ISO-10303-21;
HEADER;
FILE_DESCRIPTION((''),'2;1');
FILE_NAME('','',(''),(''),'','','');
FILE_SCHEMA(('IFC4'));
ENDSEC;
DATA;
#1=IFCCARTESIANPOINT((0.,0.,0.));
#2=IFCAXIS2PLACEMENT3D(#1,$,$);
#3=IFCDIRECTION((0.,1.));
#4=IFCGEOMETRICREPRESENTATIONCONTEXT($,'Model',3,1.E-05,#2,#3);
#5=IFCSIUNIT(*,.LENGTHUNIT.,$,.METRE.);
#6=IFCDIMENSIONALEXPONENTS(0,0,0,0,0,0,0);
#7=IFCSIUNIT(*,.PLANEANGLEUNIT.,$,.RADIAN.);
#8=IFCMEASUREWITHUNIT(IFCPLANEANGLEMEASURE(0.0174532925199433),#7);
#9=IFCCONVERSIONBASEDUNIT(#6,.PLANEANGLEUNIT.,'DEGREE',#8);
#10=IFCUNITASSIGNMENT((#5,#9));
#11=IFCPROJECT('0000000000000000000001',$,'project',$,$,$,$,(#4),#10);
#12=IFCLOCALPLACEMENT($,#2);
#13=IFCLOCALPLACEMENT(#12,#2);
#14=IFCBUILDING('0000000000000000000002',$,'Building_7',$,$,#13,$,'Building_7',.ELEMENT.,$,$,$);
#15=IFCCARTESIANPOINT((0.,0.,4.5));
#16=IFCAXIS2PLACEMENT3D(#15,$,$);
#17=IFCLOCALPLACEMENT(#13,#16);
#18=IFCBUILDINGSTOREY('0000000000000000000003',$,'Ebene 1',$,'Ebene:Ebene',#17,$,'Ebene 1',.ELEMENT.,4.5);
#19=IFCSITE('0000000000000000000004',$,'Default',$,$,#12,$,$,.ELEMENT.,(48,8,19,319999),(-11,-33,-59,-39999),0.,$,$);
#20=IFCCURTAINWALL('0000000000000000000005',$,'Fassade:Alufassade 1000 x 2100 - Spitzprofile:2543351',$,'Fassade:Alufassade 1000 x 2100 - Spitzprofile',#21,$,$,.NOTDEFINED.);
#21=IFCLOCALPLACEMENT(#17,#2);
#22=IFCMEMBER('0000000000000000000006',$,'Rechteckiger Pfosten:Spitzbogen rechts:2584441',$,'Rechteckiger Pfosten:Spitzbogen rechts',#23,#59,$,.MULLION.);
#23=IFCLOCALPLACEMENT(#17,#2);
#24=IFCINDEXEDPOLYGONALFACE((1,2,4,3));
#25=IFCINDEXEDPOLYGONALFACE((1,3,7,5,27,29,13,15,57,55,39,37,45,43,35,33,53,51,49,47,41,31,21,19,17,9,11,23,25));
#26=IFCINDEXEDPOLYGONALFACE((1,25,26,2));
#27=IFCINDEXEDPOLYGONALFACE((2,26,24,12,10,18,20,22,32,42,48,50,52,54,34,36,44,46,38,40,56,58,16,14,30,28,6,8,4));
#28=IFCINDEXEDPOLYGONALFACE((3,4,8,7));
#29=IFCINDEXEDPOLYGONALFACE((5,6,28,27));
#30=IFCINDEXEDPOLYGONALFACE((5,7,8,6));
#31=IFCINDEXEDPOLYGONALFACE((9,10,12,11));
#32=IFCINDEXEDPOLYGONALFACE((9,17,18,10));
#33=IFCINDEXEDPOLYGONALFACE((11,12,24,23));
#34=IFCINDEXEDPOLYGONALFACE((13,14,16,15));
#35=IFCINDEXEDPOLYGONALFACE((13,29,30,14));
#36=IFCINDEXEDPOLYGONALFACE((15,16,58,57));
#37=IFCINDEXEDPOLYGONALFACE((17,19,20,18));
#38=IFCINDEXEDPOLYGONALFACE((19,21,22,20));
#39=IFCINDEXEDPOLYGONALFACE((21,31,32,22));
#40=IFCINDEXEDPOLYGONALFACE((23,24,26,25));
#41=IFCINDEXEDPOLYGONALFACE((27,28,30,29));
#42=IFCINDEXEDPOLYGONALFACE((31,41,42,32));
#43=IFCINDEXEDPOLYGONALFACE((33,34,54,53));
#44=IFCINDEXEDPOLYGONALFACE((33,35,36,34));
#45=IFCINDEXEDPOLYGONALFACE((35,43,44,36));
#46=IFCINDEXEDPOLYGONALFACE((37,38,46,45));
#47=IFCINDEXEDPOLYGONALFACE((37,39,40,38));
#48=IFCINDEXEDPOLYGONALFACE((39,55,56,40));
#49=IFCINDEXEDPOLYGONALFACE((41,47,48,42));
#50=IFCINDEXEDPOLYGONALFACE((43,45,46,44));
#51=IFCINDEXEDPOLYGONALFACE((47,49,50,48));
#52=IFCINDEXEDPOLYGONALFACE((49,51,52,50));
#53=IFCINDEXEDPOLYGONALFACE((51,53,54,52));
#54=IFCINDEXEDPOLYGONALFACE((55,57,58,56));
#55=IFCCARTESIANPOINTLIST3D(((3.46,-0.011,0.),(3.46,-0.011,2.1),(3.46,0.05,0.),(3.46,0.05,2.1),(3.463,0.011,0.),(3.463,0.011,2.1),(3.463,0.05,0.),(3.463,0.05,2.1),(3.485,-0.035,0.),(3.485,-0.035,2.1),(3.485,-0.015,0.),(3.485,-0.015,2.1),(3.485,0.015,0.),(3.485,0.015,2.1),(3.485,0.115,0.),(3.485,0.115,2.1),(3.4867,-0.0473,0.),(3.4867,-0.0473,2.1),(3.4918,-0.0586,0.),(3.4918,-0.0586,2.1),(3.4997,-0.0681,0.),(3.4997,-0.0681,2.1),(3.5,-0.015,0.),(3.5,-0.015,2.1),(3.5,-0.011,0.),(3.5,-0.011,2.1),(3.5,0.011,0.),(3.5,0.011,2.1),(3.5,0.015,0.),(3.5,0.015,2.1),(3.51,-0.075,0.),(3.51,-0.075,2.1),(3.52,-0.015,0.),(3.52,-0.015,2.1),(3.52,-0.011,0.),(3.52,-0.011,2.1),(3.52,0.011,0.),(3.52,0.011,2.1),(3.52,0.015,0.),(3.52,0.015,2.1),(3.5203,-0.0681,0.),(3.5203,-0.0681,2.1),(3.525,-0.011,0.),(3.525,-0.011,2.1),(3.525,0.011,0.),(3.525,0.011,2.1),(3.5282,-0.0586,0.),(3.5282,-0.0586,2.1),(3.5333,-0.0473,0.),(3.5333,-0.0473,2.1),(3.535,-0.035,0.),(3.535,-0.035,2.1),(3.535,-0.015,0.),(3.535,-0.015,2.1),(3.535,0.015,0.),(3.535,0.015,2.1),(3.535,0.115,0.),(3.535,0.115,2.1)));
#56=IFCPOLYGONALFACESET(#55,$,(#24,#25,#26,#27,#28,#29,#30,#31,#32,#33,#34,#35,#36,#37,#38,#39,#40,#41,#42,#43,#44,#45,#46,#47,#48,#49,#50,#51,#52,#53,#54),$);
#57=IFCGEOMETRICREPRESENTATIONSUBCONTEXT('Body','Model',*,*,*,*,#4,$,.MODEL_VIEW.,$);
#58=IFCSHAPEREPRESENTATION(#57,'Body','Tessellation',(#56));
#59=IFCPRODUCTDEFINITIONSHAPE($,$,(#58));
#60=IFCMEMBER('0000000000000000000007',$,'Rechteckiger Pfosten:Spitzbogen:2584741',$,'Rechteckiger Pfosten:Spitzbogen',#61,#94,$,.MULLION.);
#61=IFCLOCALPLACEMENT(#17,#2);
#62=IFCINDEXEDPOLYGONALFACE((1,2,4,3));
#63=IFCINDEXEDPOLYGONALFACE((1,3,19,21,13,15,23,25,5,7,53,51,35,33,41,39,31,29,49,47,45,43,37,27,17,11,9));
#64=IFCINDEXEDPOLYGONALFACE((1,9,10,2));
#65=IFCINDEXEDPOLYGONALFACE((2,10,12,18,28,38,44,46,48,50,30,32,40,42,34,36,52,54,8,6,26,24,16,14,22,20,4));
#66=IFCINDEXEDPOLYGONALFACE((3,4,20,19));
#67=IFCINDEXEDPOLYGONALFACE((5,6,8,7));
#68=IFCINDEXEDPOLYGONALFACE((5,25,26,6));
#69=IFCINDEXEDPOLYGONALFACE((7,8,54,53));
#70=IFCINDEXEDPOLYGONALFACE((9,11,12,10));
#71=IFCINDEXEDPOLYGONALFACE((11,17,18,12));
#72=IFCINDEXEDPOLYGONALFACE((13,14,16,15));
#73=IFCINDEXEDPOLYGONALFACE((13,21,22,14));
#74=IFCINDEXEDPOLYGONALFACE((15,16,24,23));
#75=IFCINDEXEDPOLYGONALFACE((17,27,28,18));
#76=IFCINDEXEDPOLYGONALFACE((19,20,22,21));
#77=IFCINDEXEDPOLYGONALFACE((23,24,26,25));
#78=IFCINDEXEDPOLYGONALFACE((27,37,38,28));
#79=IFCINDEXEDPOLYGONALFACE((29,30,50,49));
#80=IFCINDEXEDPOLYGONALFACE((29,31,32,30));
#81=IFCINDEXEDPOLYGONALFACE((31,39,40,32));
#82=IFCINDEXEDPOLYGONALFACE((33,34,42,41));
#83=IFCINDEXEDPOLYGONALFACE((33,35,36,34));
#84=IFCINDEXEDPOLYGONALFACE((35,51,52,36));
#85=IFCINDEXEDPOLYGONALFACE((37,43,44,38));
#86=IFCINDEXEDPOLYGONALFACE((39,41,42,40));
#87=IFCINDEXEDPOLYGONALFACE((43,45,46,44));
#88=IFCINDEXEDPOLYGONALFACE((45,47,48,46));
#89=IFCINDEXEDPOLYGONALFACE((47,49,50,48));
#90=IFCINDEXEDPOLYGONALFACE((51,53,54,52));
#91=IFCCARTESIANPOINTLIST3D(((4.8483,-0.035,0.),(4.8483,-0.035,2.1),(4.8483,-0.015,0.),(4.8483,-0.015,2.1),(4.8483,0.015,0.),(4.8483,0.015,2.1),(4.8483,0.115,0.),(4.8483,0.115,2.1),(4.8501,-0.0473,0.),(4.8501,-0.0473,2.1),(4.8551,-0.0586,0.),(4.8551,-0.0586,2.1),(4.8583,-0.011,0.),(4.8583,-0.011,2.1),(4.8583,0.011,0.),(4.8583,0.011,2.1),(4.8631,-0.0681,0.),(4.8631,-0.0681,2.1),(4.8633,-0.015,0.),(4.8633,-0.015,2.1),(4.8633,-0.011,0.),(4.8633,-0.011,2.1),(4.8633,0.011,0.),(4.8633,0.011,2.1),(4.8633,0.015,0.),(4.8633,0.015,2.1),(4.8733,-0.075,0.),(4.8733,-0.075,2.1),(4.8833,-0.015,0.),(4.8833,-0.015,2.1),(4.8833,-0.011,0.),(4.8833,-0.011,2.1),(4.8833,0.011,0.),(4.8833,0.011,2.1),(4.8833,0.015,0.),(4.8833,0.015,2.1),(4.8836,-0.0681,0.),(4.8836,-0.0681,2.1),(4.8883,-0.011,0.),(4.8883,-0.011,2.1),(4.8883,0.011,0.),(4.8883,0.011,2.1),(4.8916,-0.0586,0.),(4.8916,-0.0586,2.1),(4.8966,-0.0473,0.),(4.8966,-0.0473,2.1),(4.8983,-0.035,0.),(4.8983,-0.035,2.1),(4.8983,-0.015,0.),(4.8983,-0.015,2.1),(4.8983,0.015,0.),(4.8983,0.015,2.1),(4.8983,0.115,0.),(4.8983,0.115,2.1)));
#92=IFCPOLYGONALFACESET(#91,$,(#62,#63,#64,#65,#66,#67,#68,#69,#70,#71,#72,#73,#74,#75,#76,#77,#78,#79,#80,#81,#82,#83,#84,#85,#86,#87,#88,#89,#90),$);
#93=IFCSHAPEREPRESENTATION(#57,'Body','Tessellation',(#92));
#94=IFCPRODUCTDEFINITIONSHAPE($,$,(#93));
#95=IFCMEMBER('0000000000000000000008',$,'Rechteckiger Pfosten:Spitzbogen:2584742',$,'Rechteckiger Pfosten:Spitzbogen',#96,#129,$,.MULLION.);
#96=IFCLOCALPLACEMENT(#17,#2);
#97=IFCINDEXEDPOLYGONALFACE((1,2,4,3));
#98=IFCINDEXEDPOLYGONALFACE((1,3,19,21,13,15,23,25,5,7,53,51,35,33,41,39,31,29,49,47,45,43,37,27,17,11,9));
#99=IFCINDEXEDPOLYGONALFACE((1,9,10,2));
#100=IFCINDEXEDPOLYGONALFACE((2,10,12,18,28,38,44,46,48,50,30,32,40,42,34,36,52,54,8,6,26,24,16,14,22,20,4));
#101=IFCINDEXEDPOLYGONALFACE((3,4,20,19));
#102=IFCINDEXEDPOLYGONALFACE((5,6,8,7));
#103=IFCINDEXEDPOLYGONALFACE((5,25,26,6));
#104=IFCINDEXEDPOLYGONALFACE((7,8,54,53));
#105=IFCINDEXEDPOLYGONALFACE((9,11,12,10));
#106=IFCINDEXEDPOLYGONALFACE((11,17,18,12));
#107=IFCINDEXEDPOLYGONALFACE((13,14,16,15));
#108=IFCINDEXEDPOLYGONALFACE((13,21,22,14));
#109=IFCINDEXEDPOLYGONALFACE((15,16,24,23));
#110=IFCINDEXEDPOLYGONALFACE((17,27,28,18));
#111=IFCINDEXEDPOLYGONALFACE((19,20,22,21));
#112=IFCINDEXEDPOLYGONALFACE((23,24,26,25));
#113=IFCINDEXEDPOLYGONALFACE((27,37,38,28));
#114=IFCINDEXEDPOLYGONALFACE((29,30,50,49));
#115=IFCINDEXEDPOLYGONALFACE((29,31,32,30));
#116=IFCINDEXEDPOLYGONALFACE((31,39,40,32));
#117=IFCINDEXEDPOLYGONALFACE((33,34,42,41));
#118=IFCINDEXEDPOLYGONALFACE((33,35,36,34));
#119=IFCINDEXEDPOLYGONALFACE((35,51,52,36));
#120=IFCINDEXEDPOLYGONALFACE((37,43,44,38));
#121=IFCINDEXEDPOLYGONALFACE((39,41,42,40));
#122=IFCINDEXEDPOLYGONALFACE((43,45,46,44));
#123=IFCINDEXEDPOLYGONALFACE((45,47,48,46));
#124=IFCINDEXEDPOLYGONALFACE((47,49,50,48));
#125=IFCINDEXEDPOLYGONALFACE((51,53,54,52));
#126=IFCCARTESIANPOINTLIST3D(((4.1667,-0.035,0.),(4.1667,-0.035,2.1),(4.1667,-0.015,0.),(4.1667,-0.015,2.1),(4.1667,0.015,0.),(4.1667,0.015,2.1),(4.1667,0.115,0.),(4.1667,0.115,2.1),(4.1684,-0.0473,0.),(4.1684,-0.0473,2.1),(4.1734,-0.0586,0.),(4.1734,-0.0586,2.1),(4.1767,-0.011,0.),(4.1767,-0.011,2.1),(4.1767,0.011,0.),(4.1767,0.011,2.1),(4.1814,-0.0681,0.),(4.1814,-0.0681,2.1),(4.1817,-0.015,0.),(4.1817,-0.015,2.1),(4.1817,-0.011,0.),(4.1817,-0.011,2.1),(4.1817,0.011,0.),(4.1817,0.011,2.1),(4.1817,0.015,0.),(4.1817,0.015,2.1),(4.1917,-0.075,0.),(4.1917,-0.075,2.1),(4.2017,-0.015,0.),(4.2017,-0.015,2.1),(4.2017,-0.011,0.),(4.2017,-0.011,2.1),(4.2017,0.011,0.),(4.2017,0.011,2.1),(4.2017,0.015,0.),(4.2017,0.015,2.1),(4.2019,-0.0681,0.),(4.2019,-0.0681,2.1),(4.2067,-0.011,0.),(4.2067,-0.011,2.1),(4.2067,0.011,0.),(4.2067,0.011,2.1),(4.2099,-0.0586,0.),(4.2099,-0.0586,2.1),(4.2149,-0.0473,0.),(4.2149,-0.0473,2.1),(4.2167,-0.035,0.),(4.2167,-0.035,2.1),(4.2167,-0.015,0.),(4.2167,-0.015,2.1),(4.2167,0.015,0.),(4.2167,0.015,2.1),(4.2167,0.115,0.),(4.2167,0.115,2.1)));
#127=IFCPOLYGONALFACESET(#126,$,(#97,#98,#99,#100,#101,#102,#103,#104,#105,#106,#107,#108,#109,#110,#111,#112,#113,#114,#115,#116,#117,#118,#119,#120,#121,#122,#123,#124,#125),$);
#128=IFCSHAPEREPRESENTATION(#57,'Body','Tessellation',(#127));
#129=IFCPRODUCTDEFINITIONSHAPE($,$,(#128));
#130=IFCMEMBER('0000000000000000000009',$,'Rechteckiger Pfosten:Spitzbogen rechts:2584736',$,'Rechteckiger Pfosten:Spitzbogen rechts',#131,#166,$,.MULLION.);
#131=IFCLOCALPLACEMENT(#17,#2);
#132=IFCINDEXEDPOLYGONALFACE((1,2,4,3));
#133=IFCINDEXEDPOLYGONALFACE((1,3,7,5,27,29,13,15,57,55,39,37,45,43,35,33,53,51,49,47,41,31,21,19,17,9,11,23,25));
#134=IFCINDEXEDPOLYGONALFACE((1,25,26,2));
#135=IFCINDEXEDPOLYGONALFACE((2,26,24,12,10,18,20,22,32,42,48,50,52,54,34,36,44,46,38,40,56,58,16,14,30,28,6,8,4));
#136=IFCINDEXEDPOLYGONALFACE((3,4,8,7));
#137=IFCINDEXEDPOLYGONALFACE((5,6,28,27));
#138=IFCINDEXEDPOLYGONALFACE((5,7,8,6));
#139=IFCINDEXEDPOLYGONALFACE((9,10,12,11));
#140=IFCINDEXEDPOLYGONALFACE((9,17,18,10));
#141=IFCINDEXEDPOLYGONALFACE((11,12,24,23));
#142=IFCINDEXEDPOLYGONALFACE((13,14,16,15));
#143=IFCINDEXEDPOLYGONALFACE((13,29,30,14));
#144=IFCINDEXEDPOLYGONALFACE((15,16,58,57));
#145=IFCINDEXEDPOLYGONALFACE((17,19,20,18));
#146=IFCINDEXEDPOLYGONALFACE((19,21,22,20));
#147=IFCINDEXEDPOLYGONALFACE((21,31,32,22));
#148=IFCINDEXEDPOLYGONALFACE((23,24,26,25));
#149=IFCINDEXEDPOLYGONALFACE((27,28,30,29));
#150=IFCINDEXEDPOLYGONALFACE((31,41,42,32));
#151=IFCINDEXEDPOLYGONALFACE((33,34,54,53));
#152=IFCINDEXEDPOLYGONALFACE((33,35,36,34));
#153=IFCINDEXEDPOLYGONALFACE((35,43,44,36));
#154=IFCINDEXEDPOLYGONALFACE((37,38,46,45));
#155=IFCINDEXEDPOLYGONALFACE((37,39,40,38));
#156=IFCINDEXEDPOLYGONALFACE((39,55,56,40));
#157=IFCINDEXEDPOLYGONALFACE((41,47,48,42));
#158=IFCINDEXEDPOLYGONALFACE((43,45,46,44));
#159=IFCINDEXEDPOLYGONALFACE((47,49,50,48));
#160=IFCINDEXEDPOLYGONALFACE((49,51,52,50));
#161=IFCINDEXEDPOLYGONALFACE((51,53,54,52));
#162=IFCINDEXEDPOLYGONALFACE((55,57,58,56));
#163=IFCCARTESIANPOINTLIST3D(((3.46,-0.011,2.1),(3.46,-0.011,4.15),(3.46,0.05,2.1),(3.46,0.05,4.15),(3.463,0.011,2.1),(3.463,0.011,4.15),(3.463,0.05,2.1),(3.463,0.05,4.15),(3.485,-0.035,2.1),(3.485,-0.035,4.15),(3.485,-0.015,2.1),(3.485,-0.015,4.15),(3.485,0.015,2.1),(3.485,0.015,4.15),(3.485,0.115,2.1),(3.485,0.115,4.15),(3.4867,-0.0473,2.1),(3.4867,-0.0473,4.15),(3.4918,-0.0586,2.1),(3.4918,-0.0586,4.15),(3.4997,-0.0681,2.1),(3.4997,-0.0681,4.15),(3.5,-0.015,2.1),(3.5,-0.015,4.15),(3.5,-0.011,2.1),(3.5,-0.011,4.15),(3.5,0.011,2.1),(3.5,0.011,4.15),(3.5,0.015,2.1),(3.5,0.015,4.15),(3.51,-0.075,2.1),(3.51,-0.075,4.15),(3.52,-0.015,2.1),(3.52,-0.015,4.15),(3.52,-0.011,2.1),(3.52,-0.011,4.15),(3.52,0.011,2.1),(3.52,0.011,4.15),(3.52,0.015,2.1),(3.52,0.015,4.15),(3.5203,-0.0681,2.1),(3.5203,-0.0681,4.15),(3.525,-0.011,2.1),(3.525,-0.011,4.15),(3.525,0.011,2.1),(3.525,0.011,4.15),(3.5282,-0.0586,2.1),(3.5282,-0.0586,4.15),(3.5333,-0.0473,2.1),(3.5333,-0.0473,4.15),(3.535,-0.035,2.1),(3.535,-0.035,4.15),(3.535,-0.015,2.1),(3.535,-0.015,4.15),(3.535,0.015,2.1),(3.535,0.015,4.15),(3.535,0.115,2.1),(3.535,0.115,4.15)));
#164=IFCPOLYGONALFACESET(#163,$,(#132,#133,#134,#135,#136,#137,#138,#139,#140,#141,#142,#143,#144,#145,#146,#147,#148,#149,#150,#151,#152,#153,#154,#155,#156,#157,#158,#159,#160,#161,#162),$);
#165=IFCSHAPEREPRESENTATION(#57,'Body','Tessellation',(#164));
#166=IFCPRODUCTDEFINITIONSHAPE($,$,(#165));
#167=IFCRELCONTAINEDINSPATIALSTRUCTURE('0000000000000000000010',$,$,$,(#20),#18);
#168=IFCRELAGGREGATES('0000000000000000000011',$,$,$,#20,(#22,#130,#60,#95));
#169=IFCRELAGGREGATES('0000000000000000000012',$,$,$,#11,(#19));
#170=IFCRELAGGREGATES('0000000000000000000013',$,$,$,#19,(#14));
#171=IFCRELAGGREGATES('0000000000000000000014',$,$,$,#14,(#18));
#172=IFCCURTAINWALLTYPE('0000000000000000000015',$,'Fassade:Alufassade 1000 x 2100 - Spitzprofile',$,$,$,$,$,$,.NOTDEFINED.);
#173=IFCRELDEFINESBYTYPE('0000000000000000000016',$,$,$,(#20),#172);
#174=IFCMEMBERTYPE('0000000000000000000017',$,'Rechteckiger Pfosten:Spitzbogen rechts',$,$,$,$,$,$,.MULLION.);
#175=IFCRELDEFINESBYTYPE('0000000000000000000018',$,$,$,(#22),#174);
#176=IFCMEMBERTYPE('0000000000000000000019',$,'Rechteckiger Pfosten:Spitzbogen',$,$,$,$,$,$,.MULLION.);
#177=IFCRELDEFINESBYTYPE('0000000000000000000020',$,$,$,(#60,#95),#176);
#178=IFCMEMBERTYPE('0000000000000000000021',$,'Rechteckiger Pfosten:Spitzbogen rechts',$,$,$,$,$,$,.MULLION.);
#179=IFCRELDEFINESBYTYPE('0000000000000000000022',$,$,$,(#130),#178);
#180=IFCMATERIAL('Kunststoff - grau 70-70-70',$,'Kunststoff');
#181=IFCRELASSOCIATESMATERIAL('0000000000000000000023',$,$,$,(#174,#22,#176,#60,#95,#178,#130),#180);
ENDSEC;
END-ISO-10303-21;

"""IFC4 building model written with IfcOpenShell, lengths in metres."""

from ifc_helpers import new_model, entity, si_unit, converted_unit, direction, frame, origin, place, context, subcontext, project, spatial, line, arc, indexed_curve, outline, extrude, source, transform, mapped, material, type_object, type_shapes, element, aggregate, save


model = new_model("IFC4")

# Units and contexts
model_context = context("Model", 3, precision=1e-05, world=origin(), true_north=direction((0.0, 1.0)))
body_context = subcontext(model_context, "Body", "Model", "MODEL_VIEW")
ifc_project = project(units=[si_unit("LENGTHUNIT", "METRE"), converted_unit("PLANEANGLEUNIT", "DEGREE", entity("IfcPlaneAngleMeasure", 0.0174532925199433), si_unit("PLANEANGLEUNIT", "RADIAN"), dimensions=[0, 0, 0, 0, 0, 0, 0])], contexts=[model_context])

# Site, building, storey
site_placement = place(None, origin())
site = spatial("IfcSite", under=ifc_project, at=site_placement, Name="Default", CompositionType="ELEMENT", RefLatitude=(48, 8, 19, 319999), RefLongitude=(-11, -33, -59, -39999), RefElevation=0.0)
building_placement = place(site_placement, origin())
building = spatial("IfcBuilding", under=site, at=building_placement, Name="Building_7", LongName="Building_7", CompositionType="ELEMENT")
storey_placement = place(building_placement, frame((0.0, 0.0, 4.5)))
storey = spatial("IfcBuildingStorey", under=building, at=storey_placement, Name="Ebene 1", ObjectType="Ebene:Ebene", LongName="Ebene 1", CompositionType="ELEMENT", Elevation=4.5)

# Curtain wall, members
curtain_wall_type = type_object("IfcCurtainWallType", Name="Fassade:Alufassade 1000 x 2100 - Spitzprofile", PredefinedType="NOTDEFINED")
curtain_wall_placement = place(storey_placement, frame((0.0, 0.0, -4.5)))
curtain_wall = element("IfcCurtainWall", 1, at=curtain_wall_placement, inside=storey, type_object=curtain_wall_type, Name="Fassade:Alufassade 1000 x 2100 - Spitzprofile:2543351", ObjectType="Fassade:Alufassade 1000 x 2100 - Spitzprofile", PredefinedType="NOTDEFINED")
ifc_material_1 = material(Name="Kunststoff - grau 70-70-70", Category="Kunststoff")
member_type_1 = type_object("IfcMemberType", Name="Rechteckiger Pfosten:Spitzbogen rechts", PredefinedType="MULLION", material=ifc_material_1)
shared_shape_1 = source(origin(), body_context, "Body", "SweptSolid", [
    extrude(outline(indexed_curve([(-0.107, -0.0321), (-0.007, -0.0321), (-0.007, -0.0171), (-0.003, -0.0171), (-0.003, -0.0221), (0.019, -0.0221), (0.019, -0.0171), (0.023, -0.0171), (0.023, -0.0321), (0.043, -0.0321), (0.0666, -0.0254), (0.083, -0.0071), (0.0666, 0.0111), (0.043, 0.0179), (0.023, 0.0179), (0.023, 0.0029), (0.019, 0.0029), (0.019, 0.0429), (-0.042, 0.0429), (-0.042, 0.0399), (-0.003, 0.0399), (-0.003, 0.0029), (-0.007, 0.0029), (-0.007, 0.0179), (-0.107, 0.0179)], segments=[line(1, 2, 3, 4, 5, 6, 7, 8, 9, 10), arc(10, 11, 12), arc(12, 13, 14), line(14, 15, 16, 17, 18, 19, 20, 21, 22, 23, 24, 25, 1)], self_intersect=False)), frame((-0.0429, 0.008, -2.1), z_axis=(0.0, 0.0, 1.0), x_axis=(0.0, -1.0, 0.0)), (0.0, 0.0, 1.0), 2.1),
])
type_shapes(member_type_1, [shared_shape_1])
member_1_placement = place(curtain_wall_placement, frame((3.46, 0.0, 4.5), z_axis=(0.0, 0.0, -1.0), x_axis=(-1.0, 0.0, 0.0)))
member_1 = element("IfcMember", 2, at=member_1_placement, type_object=member_type_1, material=ifc_material_1, Name="Rechteckiger Pfosten:Spitzbogen rechts:2584441", ObjectType="Rechteckiger Pfosten:Spitzbogen rechts", PredefinedType="MULLION", context=body_context, shape_type="MappedRepresentation", body=[
    mapped(shared_shape_1, transform((0.0, 0.0, 0.0), scale=1.0)),
])
member_type_2 = type_object("IfcMemberType", Name="Rechteckiger Pfosten:Spitzbogen", PredefinedType="MULLION", material=ifc_material_1)
shared_shape_2 = source(origin(), body_context, "Body", "SweptSolid", [
    extrude(outline(indexed_curve([(-0.111, -0.025), (-0.011, -0.025), (-0.011, -0.01), (-0.007, -0.01), (-0.007, -0.015), (0.015, -0.015), (0.015, -0.01), (0.019, -0.01), (0.019, -0.025), (0.039, -0.025), (0.0626, -0.0182), (0.079, 0.0), (0.0626, 0.0182), (0.039, 0.025), (0.019, 0.025), (0.019, 0.01), (0.015, 0.01), (0.015, 0.015), (-0.007, 0.015), (-0.007, 0.01), (-0.011, 0.01), (-0.011, 0.025), (-0.111, 0.025)], segments=[line(1, 2, 3, 4, 5, 6, 7, 8, 9, 10), arc(10, 11, 12), arc(12, 13, 14), line(14, 15, 16, 17, 18, 19, 20, 21, 22, 23, 1)], self_intersect=False)), frame((0.0, 0.004, -2.1), z_axis=(0.0, 0.0, 1.0), x_axis=(0.0, -1.0, 0.0)), (0.0, 0.0, 1.0), 2.1),
])
type_shapes(member_type_2, [shared_shape_2])
member_2_placement = place(curtain_wall_placement, frame((4.8733, 0.0, 4.5), z_axis=(0.0, 0.0, -1.0), x_axis=(-1.0, 0.0, 0.0)))
member_2 = element("IfcMember", 3, at=member_2_placement, type_object=member_type_2, material=ifc_material_1, Name="Rechteckiger Pfosten:Spitzbogen:2584741", ObjectType="Rechteckiger Pfosten:Spitzbogen", PredefinedType="MULLION", context=body_context, shape_type="MappedRepresentation", body=[
    mapped(shared_shape_2, transform((0.0, 0.0, 0.0), scale=1.0)),
])
member_3_placement = place(curtain_wall_placement, frame((4.1917, 0.0, 4.5), z_axis=(0.0, 0.0, -1.0), x_axis=(-1.0, 0.0, 0.0)))
member_3 = element("IfcMember", 4, at=member_3_placement, type_object=member_type_2, material=ifc_material_1, Name="Rechteckiger Pfosten:Spitzbogen:2584742", ObjectType="Rechteckiger Pfosten:Spitzbogen", PredefinedType="MULLION", context=body_context, shape_type="MappedRepresentation", body=[
    mapped(shared_shape_2, transform((0.0, 0.0, 0.0), scale=1.0)),
])
member_type_3 = type_object("IfcMemberType", Name="Rechteckiger Pfosten:Spitzbogen rechts", PredefinedType="MULLION", material=ifc_material_1)
shared_shape_3 = source(origin(), body_context, "Body", "SweptSolid", [
    extrude(outline(indexed_curve([(-0.107, -0.0321), (-0.007, -0.0321), (-0.007, -0.0171), (-0.003, -0.0171), (-0.003, -0.0221), (0.019, -0.0221), (0.019, -0.0171), (0.023, -0.0171), (0.023, -0.0321), (0.043, -0.0321), (0.0666, -0.0254), (0.083, -0.0071), (0.0666, 0.0111), (0.043, 0.0179), (0.023, 0.0179), (0.023, 0.0029), (0.019, 0.0029), (0.019, 0.0429), (-0.042, 0.0429), (-0.042, 0.0399), (-0.003, 0.0399), (-0.003, 0.0029), (-0.007, 0.0029), (-0.007, 0.0179), (-0.107, 0.0179)], segments=[line(1, 2, 3, 4, 5, 6, 7, 8, 9, 10), arc(10, 11, 12), arc(12, 13, 14), line(14, 15, 16, 17, 18, 19, 20, 21, 22, 23, 24, 25, 1)], self_intersect=False)), frame((-0.0429, 0.008, -2.05), z_axis=(0.0, 0.0, 1.0), x_axis=(0.0, -1.0, 0.0)), (0.0, 0.0, 1.0), 2.05),
])
type_shapes(member_type_3, [shared_shape_3])
member_4_placement = place(curtain_wall_placement, frame((3.46, 0.0, 6.6), z_axis=(0.0, 0.0, -1.0), x_axis=(-1.0, 0.0, 0.0)))
member_4 = element("IfcMember", 5, at=member_4_placement, type_object=member_type_3, material=ifc_material_1, Name="Rechteckiger Pfosten:Spitzbogen rechts:2584736", ObjectType="Rechteckiger Pfosten:Spitzbogen rechts", PredefinedType="MULLION", context=body_context, shape_type="MappedRepresentation", body=[
    mapped(shared_shape_3, transform((0.0, 0.0, 0.0), scale=1.0)),
])

aggregate(curtain_wall, [member_1, member_4, member_2, member_3])

save(model, "model.ifc")
